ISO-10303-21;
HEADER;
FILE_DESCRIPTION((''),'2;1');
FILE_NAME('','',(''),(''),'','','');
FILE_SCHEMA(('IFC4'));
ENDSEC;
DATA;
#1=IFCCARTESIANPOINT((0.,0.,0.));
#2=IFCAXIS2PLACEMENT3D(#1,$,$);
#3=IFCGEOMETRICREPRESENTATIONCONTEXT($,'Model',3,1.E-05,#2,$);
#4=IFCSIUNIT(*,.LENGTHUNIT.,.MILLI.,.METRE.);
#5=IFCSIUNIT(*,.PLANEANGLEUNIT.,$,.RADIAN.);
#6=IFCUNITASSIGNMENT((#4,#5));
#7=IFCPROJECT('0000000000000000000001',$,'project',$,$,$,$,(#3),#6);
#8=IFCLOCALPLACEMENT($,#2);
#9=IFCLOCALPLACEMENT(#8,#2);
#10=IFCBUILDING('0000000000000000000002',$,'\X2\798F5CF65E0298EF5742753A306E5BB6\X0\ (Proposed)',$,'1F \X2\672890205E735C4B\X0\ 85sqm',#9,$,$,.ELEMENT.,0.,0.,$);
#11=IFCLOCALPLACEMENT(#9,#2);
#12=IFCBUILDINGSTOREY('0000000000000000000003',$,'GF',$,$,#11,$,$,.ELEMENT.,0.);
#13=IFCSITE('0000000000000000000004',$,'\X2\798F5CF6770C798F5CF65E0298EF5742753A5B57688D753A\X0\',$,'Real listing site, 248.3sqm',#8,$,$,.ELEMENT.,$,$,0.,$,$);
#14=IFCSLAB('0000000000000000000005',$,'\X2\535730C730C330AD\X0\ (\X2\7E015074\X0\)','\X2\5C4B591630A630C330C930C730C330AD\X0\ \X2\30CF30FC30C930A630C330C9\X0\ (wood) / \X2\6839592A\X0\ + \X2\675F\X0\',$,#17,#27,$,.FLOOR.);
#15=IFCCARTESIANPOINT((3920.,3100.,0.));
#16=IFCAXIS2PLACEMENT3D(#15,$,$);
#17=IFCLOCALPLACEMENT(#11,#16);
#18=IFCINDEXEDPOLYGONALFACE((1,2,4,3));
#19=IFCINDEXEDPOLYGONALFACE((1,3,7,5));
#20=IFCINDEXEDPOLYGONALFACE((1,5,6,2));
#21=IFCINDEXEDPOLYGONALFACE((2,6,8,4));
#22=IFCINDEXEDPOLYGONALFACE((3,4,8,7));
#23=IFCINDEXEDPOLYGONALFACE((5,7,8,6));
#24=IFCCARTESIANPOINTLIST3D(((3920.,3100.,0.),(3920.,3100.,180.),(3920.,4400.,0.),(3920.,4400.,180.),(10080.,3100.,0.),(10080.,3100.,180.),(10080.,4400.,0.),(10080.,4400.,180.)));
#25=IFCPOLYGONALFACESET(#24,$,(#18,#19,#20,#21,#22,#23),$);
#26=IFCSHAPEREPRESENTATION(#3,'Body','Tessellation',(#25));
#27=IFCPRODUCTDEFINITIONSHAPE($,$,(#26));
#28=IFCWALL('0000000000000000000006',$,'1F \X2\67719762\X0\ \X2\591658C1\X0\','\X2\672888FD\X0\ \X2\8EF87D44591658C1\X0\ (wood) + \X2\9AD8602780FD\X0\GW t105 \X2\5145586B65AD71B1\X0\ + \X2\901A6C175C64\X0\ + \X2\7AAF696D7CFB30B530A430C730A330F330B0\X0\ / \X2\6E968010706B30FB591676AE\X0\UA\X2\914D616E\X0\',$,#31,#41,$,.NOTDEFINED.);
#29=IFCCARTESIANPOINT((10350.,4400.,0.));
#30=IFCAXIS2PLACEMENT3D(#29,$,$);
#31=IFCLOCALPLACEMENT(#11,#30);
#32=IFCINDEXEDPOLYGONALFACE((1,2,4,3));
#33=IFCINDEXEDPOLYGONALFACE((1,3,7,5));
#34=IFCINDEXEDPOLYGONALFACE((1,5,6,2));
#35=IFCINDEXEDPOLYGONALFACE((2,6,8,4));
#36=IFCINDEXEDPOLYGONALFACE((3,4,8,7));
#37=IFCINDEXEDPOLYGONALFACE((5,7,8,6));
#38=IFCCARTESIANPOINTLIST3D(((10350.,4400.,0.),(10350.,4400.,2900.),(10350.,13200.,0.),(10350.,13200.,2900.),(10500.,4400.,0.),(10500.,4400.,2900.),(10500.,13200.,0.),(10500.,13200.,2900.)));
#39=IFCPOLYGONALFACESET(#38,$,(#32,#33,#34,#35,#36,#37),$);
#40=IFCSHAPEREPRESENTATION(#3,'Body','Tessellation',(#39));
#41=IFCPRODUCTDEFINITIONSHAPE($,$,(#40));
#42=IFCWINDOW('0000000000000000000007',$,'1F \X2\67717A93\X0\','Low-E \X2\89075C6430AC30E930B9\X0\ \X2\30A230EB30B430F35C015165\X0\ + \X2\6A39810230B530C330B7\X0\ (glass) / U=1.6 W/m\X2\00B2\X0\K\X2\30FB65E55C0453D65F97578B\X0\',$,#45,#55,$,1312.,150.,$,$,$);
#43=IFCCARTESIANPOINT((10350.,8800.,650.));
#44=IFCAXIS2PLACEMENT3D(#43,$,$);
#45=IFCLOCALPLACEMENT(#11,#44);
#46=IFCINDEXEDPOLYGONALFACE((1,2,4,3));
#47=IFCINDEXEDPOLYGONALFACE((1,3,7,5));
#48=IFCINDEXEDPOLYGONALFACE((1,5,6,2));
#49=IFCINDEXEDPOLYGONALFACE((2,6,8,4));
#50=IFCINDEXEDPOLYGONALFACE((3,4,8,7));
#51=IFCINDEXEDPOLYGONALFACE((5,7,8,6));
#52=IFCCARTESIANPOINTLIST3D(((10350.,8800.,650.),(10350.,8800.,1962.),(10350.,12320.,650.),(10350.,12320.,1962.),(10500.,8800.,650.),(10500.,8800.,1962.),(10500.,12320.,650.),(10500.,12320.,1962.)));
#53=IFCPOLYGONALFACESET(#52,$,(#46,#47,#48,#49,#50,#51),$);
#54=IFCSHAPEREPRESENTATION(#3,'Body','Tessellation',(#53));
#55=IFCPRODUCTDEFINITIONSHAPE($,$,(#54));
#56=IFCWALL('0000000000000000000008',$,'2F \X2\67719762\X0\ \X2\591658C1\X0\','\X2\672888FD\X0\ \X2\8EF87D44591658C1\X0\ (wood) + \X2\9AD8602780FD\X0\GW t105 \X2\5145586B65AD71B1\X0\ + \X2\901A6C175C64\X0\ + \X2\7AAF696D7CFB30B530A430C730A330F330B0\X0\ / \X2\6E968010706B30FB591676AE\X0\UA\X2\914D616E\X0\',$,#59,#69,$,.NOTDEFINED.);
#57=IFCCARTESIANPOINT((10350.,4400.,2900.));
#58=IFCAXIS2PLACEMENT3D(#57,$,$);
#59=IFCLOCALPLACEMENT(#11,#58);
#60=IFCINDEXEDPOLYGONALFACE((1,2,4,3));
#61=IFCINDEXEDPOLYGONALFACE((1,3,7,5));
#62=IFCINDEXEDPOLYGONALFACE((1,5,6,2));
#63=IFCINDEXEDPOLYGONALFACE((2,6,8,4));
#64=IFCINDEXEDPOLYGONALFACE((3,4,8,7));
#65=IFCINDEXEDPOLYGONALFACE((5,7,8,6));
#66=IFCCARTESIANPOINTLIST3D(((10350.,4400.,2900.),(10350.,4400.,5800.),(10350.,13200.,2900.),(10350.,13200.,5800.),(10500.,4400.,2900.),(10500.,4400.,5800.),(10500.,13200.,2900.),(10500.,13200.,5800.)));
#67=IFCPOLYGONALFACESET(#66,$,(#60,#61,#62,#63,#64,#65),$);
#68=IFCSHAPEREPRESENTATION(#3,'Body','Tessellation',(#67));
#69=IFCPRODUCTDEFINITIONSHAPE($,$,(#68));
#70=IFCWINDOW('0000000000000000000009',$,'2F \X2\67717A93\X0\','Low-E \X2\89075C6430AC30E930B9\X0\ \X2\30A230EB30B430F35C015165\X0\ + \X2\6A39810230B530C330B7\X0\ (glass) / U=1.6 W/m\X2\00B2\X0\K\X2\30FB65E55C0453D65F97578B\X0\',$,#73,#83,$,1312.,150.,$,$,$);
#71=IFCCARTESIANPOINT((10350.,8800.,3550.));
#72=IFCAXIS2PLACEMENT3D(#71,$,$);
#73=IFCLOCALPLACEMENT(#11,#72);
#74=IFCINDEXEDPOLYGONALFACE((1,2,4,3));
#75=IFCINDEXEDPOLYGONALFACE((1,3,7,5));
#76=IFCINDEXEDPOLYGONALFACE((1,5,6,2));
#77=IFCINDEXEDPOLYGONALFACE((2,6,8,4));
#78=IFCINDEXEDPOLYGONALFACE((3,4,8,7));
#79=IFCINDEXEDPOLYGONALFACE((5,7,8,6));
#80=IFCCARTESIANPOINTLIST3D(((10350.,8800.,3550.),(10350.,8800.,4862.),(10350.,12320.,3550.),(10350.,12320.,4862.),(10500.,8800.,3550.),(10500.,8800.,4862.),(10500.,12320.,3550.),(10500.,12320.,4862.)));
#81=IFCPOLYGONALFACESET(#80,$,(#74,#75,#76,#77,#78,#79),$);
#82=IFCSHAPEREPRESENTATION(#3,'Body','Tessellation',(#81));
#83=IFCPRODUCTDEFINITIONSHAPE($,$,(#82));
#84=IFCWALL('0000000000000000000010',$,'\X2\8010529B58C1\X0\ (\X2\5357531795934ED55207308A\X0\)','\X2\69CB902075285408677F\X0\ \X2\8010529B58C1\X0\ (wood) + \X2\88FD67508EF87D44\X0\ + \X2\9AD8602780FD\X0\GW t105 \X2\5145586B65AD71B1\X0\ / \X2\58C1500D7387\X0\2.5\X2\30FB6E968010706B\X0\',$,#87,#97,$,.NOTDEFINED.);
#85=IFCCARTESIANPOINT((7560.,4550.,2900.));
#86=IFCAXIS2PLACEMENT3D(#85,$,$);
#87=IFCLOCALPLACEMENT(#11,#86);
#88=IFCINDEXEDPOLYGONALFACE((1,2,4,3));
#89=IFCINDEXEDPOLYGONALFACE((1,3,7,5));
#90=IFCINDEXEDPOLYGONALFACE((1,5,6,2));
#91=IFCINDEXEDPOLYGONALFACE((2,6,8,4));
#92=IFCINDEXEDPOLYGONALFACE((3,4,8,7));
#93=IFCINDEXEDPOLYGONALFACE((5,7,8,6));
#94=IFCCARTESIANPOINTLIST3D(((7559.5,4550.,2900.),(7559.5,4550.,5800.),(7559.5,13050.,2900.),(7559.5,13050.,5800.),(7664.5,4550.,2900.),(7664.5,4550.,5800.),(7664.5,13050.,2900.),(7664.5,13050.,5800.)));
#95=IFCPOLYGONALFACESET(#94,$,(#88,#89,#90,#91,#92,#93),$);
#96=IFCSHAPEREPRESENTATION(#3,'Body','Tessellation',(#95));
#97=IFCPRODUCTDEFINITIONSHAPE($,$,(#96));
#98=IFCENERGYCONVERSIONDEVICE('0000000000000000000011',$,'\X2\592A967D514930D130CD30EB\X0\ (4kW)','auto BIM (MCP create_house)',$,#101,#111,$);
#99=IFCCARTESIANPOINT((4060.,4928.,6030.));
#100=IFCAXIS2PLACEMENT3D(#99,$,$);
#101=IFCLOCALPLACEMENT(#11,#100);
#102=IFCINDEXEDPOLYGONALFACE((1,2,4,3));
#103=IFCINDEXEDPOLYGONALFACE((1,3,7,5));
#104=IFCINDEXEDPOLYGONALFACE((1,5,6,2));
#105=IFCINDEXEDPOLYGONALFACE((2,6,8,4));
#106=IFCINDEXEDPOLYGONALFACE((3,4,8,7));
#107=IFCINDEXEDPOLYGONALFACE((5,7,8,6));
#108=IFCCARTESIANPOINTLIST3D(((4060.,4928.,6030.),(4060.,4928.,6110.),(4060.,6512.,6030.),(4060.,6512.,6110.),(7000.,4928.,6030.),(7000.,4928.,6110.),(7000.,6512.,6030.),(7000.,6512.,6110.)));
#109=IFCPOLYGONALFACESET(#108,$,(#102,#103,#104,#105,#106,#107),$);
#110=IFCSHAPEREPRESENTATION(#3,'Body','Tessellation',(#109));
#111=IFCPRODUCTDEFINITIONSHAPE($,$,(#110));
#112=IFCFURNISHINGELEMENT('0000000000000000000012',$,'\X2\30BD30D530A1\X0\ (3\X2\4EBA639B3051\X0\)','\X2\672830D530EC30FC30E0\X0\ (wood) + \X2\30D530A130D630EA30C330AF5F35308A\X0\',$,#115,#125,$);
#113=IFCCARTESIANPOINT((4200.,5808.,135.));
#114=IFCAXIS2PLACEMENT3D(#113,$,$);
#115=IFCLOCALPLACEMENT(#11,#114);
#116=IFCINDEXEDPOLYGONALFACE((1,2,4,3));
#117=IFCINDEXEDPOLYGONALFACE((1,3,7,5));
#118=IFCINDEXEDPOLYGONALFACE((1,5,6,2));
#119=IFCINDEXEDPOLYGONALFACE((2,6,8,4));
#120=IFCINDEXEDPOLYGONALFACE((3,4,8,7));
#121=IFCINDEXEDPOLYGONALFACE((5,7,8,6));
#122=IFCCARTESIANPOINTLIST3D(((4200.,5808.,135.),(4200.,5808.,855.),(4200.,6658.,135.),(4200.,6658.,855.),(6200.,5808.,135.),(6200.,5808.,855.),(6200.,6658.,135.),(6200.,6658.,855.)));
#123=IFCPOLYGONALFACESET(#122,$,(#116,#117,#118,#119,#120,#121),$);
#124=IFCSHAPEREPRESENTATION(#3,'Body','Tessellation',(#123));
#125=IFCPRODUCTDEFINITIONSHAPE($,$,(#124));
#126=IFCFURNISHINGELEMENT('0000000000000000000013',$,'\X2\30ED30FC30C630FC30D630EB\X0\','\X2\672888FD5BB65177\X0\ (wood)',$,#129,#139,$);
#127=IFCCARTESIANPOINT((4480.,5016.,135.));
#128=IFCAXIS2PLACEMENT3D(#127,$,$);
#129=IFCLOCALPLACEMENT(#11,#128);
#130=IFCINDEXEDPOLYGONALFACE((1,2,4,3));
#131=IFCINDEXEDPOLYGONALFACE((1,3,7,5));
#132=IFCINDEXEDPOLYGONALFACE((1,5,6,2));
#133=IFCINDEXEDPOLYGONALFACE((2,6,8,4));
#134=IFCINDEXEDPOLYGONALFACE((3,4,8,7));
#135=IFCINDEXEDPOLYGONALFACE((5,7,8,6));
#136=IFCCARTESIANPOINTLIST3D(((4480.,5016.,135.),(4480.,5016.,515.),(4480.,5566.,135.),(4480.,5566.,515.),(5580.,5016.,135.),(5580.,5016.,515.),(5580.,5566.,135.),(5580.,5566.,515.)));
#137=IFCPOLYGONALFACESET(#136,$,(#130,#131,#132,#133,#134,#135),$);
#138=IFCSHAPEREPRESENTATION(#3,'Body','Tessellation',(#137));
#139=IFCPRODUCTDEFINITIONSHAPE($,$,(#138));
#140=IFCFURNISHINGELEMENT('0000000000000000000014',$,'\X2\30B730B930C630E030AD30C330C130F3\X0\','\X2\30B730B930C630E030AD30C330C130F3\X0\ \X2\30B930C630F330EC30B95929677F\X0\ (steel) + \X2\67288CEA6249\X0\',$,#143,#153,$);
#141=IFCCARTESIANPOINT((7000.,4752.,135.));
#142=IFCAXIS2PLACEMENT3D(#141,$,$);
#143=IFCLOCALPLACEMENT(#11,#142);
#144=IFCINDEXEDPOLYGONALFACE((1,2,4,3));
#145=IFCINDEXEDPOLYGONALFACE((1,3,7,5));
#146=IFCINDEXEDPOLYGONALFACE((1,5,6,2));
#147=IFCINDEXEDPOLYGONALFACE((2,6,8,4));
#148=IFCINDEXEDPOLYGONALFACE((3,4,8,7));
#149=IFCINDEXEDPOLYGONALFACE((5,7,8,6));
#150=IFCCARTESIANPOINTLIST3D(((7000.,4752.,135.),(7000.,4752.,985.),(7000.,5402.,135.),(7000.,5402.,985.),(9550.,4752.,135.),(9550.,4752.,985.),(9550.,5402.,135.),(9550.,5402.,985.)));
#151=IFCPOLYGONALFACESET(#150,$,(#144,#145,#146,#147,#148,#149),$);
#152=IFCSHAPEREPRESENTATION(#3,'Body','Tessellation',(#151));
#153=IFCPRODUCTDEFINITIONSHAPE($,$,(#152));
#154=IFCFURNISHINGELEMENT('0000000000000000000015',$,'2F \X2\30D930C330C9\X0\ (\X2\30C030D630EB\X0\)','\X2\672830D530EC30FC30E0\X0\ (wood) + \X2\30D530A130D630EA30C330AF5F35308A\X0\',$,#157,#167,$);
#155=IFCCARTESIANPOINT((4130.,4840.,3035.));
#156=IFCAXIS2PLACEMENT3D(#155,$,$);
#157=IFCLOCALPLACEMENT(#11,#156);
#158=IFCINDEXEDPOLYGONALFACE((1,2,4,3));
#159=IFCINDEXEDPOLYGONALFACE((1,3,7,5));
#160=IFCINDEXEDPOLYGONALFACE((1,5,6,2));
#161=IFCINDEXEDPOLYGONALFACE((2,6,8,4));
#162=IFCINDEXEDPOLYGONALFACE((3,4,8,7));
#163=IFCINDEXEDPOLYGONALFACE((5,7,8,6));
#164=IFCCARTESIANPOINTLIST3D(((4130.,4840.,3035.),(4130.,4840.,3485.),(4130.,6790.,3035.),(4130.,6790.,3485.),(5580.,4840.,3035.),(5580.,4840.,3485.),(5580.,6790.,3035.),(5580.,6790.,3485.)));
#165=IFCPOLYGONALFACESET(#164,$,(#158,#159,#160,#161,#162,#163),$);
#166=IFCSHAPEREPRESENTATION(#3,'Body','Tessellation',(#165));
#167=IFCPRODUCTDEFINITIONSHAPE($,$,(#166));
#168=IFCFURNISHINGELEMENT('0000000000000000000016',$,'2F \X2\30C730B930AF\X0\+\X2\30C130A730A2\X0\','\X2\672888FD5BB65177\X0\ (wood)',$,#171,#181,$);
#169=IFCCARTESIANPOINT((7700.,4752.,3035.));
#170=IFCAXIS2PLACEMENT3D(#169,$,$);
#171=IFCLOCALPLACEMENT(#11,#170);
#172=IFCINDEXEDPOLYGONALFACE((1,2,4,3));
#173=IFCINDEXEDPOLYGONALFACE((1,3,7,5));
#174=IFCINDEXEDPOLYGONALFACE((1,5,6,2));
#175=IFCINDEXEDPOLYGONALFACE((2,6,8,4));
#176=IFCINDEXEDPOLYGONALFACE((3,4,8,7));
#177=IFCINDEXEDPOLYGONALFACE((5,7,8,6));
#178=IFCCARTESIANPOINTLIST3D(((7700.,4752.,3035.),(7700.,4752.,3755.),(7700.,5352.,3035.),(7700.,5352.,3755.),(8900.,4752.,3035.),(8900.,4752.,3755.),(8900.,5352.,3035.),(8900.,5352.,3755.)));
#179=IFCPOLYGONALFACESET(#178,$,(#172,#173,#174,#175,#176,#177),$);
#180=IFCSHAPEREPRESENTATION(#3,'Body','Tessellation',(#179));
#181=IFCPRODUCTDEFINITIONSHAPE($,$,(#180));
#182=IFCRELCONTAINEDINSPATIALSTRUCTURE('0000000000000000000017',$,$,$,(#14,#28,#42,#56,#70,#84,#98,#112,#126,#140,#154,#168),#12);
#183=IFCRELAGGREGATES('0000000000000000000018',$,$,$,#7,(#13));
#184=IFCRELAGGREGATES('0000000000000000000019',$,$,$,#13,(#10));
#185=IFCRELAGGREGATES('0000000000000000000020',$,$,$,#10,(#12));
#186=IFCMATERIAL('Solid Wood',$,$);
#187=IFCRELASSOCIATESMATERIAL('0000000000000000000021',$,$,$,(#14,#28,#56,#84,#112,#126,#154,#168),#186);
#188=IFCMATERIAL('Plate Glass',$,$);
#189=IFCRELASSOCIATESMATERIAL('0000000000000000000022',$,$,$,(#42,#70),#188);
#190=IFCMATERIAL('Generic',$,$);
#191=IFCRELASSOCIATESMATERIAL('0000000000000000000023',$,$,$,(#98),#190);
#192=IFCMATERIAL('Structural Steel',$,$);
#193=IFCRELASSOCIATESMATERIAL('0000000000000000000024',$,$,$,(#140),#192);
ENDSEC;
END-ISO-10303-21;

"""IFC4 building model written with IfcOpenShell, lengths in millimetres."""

from ifc_helpers import new_model, si_unit, frame, frame_2d, origin, place, context, project, spatial, rectangle, extrude, material, element, fill, save


model = new_model("IFC4")

# Units and contexts
model_context = context("Model", 3, precision=1e-05, world=origin())
ifc_project = project(units=[si_unit("LENGTHUNIT", "METRE", prefix="MILLI"), si_unit("PLANEANGLEUNIT", "RADIAN")], contexts=[model_context])

# Site, building, storey
site_placement = place(None, origin())
site = spatial("IfcSite", under=ifc_project, at=site_placement, Name="福島県福島市飯坂町字梍町", ObjectType="Real listing site, 248.3sqm", CompositionType="ELEMENT", RefElevation=0.0)
building_placement = place(site_placement, origin())
building = spatial("IfcBuilding", under=site, at=building_placement, Name="福島市飯坂町の家 (Proposed)", ObjectType="1F 木造平屋 85sqm", CompositionType="ELEMENT", ElevationOfRefHeight=0.0, ElevationOfTerrain=0.0)
storey_placement = place(building_placement, origin())
storey = spatial("IfcBuildingStorey", under=building, at=storey_placement, Name="GF", CompositionType="ELEMENT", Elevation=0.0)

# Slab
ifc_material_1 = material(Name="Solid Wood")
slab_placement = place(storey_placement, frame((3920.0, 3100.0, 0.0)))
element("IfcSlab", 1, at=slab_placement, inside=storey, material=ifc_material_1, Name="南デッキ (縁側)", Description="屋外ウッドデッキ ハードウッド (wood) / 根太 + 束", PredefinedType="FLOOR", context=model_context, shape_type="SweptSolid", body=[
    extrude(rectangle(XDim=6160.0, YDim=1300.0, at=frame_2d((3080.0, 650.0))), frame((3920.0, 3100.0, 0.0)), (0.0, 0.0, 1.0), 180.0),
])

# Wall, opening, window
wall_1_placement = place(storey_placement, frame((10350.0, 4400.0, 0.0)))
wall_1 = element("IfcWall", 2, at=wall_1_placement, inside=storey, material=ifc_material_1, Name="1F 東面 外壁", Description="木製 軸組外壁 (wood) + 高性能GW t105 充填断熱 + 通気層 + 窯業系サイディング / 準耐火・外皮UA配慮", PredefinedType="NOTDEFINED", context=model_context, shape_type="SweptSolid", body=[
    extrude(rectangle(XDim=150.0, YDim=8800.0, at=frame_2d((75.0, 4400.0))), frame((10350.0, 4400.0, 0.0)), (0.0, 0.0, 1.0), 2900.0),
])
opening_1_placement = place(storey_placement, frame((10350.0, 8800.0, 650.0)))
opening_1 = element("IfcOpeningElement", 3, at=opening_1_placement, cuts=wall_1, PredefinedType="NOTDEFINED", context=model_context, shape_type="SweptSolid", body=[
    extrude(rectangle(XDim=150.0, YDim=3520.0, at=frame_2d((75.0, 1760.0))), frame((10350.0, 8800.0, 650.0)), (0.0, 0.0, 1.0), 1312.0),
])
ifc_material_2 = material(Name="Plate Glass")
window_1_placement = place(storey_placement, frame((10350.0, 8800.0, 650.0)))
window_1 = element("IfcWindow", 4, at=window_1_placement, inside=storey, material=ifc_material_2, Name="1F 東窓", Description="Low-E 複層ガラス アルゴン封入 + 樹脂サッシ (glass) / U=1.6 W/m²K・日射取得型", OverallHeight=1312.0, OverallWidth=150.0, context=model_context, shape_type="SweptSolid", body=[
    extrude(rectangle(XDim=150.0, YDim=3520.0, at=frame_2d((75.0, 1760.0))), frame((10350.0, 8800.0, 650.0)), (0.0, 0.0, 1.0), 1312.0),
])
fill(opening_1, window_1)

# Wall, opening, window
wall_2_placement = place(storey_placement, frame((10350.0, 4400.0, 2900.0)))
wall_2 = element("IfcWall", 5, at=wall_2_placement, inside=storey, material=ifc_material_1, Name="2F 東面 外壁", Description="木製 軸組外壁 (wood) + 高性能GW t105 充填断熱 + 通気層 + 窯業系サイディング / 準耐火・外皮UA配慮", PredefinedType="NOTDEFINED", context=model_context, shape_type="SweptSolid", body=[
    extrude(rectangle(XDim=150.0, YDim=8800.0, at=frame_2d((75.0, 4400.0))), frame((10350.0, 4400.0, 2900.0)), (0.0, 0.0, 1.0), 2900.0),
])
opening_2_placement = place(storey_placement, frame((10350.0, 8800.0, 3550.0)))
opening_2 = element("IfcOpeningElement", 6, at=opening_2_placement, cuts=wall_2, PredefinedType="NOTDEFINED", context=model_context, shape_type="SweptSolid", body=[
    extrude(rectangle(XDim=150.0, YDim=3520.0, at=frame_2d((75.0, 1760.0))), frame((10350.0, 8800.0, 3550.0)), (0.0, 0.0, 1.0), 1312.0),
])
window_2_placement = place(storey_placement, frame((10350.0, 8800.0, 3550.0)))
window_2 = element("IfcWindow", 7, at=window_2_placement, inside=storey, material=ifc_material_2, Name="2F 東窓", Description="Low-E 複層ガラス アルゴン封入 + 樹脂サッシ (glass) / U=1.6 W/m²K・日射取得型", OverallHeight=1312.0, OverallWidth=150.0, context=model_context, shape_type="SweptSolid", body=[
    extrude(rectangle(XDim=150.0, YDim=3520.0, at=frame_2d((75.0, 1760.0))), frame((10350.0, 8800.0, 3550.0)), (0.0, 0.0, 1.0), 1312.0),
])
fill(opening_2, window_2)

# Wall
wall_3_placement = place(storey_placement, frame((7560.0, 4550.0, 2900.0)))
element("IfcWall", 8, at=wall_3_placement, inside=storey, material=ifc_material_1, Name="耐力壁 (南北間仕切り)", Description="構造用合板 耐力壁 (wood) + 製材軸組 + 高性能GW t105 充填断熱 / 壁倍率2.5・準耐火", PredefinedType="NOTDEFINED", context=model_context, shape_type="SweptSolid", body=[
    extrude(rectangle(XDim=105.0, YDim=8500.0, at=frame_2d((52.0, 4250.0))), frame((7560.0, 4550.0, 2900.0)), (0.0, 0.0, 1.0), 2900.0),
])

# Energy conversion device
ifc_material_3 = material(Name="Generic")
energy_conversion_device_placement = place(storey_placement, frame((4060.0, 4928.0, 6030.0)))
element("IfcEnergyConversionDevice", 9, at=energy_conversion_device_placement, inside=storey, material=ifc_material_3, Name="太陽光パネル (4kW)", Description="auto BIM (MCP create_house)", context=model_context, shape_type="SweptSolid", body=[
    extrude(rectangle(XDim=2940.0, YDim=1584.0, at=frame_2d((1470.0, 792.0))), frame((4060.0, 4928.0, 6030.0)), (0.0, 0.0, 1.0), 80.0),
])

# Furnishing elements
furnishing_1_placement = place(storey_placement, frame((4200.0, 5808.0, 135.0)))
element("IfcFurnishingElement", 10, at=furnishing_1_placement, inside=storey, material=ifc_material_1, Name="ソファ (3人掛け)", Description="木フレーム (wood) + ファブリック張り", context=model_context, shape_type="SweptSolid", body=[
    extrude(rectangle(XDim=2000.0, YDim=850.0, at=frame_2d((1000.0, 425.0))), frame((4200.0, 5808.0, 135.0)), (0.0, 0.0, 1.0), 720.0),
])
furnishing_2_placement = place(storey_placement, frame((4480.0, 5016.0, 135.0)))
element("IfcFurnishingElement", 11, at=furnishing_2_placement, inside=storey, material=ifc_material_1, Name="ローテーブル", Description="木製家具 (wood)", context=model_context, shape_type="SweptSolid", body=[
    extrude(rectangle(XDim=1100.0, YDim=550.0, at=frame_2d((550.0, 275.0))), frame((4480.0, 5016.0, 135.0)), (0.0, 0.0, 1.0), 380.0),
])
ifc_material_4 = material(Name="Structural Steel")
furnishing_3_placement = place(storey_placement, frame((7000.0, 4752.0, 135.0)))
element("IfcFurnishingElement", 12, at=furnishing_3_placement, inside=storey, material=ifc_material_4, Name="システムキッチン", Description="システムキッチン ステンレス天板 (steel) + 木質扉", context=model_context, shape_type="SweptSolid", body=[
    extrude(rectangle(XDim=2550.0, YDim=650.0, at=frame_2d((1275.0, 325.0))), frame((7000.0, 4752.0, 135.0)), (0.0, 0.0, 1.0), 850.0),
])
furnishing_4_placement = place(storey_placement, frame((4130.0, 4840.0, 3035.0)))
element("IfcFurnishingElement", 13, at=furnishing_4_placement, inside=storey, material=ifc_material_1, Name="2F ベッド (ダブル)", Description="木フレーム (wood) + ファブリック張り", context=model_context, shape_type="SweptSolid", body=[
    extrude(rectangle(XDim=1450.0, YDim=1950.0, at=frame_2d((725.0, 975.0))), frame((4130.0, 4840.0, 3035.0)), (0.0, 0.0, 1.0), 450.0),
])
furnishing_5_placement = place(storey_placement, frame((7700.0, 4752.0, 3035.0)))
element("IfcFurnishingElement", 14, at=furnishing_5_placement, inside=storey, material=ifc_material_1, Name="2F デスク+チェア", Description="木製家具 (wood)", context=model_context, shape_type="SweptSolid", body=[
    extrude(rectangle(XDim=1200.0, YDim=600.0, at=frame_2d((600.0, 300.0))), frame((7700.0, 4752.0, 3035.0)), (0.0, 0.0, 1.0), 720.0),
])

save(model, "model.ifc")
